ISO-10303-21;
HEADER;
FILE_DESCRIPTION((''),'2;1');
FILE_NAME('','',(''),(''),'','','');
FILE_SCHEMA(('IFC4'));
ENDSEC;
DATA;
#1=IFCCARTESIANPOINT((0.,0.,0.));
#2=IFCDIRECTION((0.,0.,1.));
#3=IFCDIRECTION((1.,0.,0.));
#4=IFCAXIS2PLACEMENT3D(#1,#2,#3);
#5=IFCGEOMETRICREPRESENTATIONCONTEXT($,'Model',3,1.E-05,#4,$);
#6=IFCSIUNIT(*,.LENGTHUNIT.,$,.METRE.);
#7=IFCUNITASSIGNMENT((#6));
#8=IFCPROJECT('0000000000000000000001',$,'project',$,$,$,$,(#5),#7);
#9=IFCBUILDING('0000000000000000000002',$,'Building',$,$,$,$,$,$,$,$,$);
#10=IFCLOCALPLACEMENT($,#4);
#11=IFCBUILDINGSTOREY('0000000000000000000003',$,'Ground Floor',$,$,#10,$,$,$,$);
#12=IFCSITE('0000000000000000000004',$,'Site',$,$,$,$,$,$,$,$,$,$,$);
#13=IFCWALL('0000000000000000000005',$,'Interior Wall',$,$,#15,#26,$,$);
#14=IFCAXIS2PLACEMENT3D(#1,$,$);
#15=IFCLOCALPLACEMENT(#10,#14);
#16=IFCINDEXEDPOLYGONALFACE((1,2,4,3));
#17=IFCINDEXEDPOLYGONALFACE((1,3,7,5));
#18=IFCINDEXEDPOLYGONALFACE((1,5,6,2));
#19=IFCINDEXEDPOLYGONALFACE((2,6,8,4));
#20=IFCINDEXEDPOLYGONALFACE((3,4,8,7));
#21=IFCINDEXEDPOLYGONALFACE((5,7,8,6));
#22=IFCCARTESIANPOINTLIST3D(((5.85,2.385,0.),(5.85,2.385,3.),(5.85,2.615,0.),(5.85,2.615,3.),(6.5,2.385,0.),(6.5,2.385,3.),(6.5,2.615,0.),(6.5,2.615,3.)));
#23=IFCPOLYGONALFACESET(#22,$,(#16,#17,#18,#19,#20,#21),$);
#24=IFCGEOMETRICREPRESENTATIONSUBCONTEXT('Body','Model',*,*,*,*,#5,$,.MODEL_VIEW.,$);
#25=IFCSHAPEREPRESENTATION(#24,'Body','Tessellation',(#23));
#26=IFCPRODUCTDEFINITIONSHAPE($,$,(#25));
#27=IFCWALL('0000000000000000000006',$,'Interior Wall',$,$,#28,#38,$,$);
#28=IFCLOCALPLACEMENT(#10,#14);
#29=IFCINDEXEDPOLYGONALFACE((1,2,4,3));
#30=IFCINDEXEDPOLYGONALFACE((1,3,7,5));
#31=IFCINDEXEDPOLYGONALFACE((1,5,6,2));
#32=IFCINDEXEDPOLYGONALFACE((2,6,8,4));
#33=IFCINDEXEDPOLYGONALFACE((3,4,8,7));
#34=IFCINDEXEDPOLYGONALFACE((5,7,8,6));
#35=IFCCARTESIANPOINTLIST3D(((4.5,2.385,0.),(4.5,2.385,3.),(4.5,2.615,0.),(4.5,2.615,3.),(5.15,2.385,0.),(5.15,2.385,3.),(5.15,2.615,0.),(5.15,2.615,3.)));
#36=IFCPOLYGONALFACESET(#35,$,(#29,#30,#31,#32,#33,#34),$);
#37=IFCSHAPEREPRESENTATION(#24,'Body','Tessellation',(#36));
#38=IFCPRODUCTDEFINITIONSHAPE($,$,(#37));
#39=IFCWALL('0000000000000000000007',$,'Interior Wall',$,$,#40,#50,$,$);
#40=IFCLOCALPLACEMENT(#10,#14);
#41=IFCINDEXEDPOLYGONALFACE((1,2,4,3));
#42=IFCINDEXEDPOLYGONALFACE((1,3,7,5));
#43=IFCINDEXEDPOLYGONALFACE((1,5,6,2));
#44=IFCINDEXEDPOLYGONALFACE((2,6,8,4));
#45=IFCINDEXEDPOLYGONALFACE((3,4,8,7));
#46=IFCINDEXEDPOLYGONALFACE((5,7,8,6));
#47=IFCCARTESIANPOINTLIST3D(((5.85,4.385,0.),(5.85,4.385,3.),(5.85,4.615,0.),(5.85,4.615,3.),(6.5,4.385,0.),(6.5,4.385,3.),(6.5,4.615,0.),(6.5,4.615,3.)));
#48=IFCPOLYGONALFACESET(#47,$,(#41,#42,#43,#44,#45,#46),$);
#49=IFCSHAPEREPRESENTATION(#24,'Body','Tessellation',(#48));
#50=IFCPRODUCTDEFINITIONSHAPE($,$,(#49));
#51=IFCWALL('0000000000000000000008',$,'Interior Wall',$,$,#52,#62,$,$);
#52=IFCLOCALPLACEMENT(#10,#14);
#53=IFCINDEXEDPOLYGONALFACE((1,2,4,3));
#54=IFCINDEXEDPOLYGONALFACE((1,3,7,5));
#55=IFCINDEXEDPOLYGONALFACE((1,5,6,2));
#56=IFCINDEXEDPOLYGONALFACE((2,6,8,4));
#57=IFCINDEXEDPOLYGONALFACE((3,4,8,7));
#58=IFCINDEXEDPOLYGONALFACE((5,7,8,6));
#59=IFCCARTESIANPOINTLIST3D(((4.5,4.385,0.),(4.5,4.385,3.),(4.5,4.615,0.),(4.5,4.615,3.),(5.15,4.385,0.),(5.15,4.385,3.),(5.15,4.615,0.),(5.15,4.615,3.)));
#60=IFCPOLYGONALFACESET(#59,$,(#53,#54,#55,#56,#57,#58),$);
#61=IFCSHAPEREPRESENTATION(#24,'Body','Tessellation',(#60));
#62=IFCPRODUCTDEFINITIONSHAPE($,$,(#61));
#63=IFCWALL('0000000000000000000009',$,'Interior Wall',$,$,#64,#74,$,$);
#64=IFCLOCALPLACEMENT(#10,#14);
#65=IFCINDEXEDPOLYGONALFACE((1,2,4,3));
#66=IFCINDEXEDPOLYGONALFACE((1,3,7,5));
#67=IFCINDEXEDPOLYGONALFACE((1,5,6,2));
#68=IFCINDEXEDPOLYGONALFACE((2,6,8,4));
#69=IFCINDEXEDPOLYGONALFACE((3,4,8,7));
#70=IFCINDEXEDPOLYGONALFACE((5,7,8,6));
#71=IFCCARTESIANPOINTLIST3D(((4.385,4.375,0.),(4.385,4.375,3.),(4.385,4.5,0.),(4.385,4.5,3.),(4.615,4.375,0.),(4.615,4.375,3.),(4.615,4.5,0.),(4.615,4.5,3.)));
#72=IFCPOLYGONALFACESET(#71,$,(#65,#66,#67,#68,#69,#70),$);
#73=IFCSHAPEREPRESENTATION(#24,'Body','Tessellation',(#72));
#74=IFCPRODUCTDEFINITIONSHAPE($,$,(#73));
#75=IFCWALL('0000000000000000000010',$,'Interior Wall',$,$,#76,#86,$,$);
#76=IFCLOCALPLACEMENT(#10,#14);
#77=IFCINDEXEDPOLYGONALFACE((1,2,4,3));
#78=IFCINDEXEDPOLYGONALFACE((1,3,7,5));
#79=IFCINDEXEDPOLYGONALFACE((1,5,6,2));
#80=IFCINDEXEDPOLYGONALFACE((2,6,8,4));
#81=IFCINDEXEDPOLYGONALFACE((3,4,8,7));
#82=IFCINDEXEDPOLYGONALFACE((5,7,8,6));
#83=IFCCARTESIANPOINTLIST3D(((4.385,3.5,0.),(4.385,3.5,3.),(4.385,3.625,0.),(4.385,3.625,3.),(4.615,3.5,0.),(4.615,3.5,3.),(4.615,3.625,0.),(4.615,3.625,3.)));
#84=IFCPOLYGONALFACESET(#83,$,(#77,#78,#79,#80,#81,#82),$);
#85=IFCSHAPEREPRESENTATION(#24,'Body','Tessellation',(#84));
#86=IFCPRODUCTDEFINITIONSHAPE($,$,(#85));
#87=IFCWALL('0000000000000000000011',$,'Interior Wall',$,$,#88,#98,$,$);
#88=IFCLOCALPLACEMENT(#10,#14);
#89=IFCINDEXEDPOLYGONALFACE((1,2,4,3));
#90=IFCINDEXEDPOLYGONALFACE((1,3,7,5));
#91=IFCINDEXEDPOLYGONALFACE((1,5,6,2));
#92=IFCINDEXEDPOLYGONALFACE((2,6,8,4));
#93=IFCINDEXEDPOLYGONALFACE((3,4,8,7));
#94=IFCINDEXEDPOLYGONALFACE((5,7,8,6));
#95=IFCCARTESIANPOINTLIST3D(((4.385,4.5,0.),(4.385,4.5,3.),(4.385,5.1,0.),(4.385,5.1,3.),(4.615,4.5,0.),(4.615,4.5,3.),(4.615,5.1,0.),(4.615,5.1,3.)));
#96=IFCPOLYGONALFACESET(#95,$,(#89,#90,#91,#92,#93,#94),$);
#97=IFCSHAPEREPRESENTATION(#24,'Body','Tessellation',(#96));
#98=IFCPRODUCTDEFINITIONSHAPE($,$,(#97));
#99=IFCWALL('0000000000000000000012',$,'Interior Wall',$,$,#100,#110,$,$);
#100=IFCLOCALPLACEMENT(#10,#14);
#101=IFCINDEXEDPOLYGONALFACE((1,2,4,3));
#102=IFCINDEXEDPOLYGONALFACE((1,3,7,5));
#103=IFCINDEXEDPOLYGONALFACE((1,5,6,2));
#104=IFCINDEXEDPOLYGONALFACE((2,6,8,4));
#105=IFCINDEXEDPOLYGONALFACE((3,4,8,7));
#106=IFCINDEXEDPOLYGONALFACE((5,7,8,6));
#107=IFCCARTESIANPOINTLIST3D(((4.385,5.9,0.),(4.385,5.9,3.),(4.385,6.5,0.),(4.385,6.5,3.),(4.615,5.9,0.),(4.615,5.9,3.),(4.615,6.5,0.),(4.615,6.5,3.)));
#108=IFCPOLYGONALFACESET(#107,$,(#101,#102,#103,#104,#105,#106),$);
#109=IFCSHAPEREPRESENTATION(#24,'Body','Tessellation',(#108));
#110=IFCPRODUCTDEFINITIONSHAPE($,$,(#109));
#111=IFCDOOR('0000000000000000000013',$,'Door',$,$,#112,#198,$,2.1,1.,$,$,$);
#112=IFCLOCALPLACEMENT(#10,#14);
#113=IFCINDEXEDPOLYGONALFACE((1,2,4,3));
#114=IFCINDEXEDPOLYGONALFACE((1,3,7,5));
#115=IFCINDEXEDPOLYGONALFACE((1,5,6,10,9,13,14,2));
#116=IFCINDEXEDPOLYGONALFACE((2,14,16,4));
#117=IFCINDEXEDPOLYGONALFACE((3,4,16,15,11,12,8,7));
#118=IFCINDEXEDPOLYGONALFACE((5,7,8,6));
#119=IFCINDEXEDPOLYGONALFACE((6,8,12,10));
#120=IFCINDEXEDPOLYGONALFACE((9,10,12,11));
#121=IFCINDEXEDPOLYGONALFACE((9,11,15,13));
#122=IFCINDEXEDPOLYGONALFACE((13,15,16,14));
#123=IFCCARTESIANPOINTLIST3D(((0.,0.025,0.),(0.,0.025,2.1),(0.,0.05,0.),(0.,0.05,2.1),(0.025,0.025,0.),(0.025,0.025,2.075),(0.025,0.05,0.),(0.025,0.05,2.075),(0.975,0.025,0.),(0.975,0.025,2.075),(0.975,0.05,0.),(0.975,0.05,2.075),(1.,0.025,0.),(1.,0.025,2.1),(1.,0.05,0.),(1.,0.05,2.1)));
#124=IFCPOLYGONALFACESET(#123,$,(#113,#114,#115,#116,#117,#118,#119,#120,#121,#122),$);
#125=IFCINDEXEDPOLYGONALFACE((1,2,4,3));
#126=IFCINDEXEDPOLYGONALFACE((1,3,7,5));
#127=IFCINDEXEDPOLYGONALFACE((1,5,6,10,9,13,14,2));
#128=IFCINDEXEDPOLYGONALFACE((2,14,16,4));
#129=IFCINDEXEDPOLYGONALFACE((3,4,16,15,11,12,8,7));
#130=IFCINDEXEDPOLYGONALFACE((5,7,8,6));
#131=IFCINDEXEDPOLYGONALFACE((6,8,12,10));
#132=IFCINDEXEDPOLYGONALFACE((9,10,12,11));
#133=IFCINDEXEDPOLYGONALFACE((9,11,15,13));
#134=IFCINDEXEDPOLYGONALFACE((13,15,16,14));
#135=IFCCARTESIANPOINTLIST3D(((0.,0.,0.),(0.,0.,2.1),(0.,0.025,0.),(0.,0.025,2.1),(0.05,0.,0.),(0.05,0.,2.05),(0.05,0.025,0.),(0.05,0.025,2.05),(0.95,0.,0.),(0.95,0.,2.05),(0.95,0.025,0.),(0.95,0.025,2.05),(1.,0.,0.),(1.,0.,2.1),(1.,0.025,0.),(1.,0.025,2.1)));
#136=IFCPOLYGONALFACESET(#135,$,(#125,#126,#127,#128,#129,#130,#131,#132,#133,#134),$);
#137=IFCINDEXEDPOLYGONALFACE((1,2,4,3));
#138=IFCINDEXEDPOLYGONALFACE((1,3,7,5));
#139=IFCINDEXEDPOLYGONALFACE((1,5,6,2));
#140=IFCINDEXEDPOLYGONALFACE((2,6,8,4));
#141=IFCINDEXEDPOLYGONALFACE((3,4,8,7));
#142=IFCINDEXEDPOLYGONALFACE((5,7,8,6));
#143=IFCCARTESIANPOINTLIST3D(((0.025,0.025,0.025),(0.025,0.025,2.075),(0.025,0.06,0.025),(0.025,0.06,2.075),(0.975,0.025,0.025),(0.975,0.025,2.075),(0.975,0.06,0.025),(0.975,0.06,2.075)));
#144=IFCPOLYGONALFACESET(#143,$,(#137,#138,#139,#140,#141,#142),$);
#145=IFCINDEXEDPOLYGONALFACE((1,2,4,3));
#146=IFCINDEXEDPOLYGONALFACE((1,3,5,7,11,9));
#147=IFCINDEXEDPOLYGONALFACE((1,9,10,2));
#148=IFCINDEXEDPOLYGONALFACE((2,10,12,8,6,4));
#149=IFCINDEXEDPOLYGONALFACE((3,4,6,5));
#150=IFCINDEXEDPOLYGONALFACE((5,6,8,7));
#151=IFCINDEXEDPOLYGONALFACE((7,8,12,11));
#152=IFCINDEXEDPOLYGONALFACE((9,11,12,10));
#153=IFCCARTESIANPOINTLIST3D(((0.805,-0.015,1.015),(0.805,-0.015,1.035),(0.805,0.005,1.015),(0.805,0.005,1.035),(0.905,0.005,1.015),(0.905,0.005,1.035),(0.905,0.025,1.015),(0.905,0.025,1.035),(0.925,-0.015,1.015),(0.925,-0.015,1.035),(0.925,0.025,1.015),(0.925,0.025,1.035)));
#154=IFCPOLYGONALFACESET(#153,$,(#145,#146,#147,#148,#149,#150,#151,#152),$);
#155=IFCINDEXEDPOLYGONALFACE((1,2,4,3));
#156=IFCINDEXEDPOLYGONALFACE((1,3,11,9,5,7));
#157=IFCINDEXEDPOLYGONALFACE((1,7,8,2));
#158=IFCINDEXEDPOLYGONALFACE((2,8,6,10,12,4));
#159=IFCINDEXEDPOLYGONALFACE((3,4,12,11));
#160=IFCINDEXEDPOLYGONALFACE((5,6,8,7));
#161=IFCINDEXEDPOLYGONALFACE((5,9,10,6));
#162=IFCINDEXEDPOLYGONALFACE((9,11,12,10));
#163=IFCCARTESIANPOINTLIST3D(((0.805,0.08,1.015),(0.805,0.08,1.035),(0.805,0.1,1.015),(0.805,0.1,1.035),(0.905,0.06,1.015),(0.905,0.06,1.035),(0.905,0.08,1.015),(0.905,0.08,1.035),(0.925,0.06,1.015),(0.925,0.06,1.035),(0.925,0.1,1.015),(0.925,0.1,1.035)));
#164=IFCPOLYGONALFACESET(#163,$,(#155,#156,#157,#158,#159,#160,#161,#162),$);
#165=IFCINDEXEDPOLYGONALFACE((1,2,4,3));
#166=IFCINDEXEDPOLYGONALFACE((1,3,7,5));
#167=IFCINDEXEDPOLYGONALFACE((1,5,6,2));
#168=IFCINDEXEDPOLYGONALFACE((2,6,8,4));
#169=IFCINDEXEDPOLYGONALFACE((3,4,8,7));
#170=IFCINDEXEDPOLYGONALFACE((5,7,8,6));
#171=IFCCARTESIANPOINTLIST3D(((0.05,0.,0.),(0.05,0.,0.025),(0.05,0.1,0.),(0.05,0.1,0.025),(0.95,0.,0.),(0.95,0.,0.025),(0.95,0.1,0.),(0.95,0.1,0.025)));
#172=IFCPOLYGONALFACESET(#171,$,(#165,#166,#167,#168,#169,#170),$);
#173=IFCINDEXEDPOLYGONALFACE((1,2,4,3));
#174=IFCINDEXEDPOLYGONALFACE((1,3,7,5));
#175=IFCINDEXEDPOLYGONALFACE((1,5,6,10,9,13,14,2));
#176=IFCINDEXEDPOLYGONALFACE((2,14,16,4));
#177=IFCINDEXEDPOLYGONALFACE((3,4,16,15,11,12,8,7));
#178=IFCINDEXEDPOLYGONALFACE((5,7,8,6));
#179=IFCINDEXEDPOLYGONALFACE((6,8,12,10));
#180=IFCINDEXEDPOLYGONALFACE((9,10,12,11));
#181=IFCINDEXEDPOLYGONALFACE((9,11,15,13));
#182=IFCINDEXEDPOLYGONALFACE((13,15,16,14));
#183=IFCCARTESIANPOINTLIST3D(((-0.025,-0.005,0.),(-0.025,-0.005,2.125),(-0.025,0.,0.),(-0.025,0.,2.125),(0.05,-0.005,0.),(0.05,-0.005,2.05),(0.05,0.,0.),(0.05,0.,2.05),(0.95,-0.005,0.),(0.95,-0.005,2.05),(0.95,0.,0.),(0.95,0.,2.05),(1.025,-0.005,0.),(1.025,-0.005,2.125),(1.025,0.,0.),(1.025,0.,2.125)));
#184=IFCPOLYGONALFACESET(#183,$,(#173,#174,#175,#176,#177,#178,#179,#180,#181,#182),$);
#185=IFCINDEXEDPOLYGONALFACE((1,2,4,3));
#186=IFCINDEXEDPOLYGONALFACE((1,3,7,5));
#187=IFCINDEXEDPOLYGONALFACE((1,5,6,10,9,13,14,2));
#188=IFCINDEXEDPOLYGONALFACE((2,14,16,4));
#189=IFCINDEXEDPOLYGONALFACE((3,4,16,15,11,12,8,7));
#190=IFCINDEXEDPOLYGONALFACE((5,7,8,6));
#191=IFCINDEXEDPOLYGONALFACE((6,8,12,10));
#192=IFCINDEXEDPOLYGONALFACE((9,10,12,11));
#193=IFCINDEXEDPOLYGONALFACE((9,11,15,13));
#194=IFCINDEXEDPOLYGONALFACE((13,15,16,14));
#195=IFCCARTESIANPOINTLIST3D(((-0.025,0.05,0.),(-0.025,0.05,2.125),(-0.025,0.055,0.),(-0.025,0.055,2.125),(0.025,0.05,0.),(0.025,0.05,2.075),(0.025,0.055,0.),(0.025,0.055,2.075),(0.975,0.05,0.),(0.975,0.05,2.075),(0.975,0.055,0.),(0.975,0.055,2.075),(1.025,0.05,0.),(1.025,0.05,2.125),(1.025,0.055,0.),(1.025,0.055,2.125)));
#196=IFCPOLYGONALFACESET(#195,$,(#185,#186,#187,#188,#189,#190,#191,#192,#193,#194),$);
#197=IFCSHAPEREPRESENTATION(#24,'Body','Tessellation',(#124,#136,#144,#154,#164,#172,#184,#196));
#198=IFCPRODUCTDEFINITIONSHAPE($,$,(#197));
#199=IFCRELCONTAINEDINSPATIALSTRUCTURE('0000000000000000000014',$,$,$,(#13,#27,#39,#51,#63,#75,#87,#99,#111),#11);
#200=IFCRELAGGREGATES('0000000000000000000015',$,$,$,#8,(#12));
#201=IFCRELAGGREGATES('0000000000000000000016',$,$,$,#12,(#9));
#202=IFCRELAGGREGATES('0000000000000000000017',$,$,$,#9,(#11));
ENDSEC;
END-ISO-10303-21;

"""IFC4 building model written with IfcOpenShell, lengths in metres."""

from ifc_helpers import new_model, si_unit, frame, origin_with_axes, place, context, subcontext, project, spatial, line, indexed_curve, outline, extrude, element, save


model = new_model("IFC4")

# Units and contexts
model_context = context("Model", 3, precision=1e-05, world=origin_with_axes())
body_context = subcontext(model_context, "Body", "Model", "MODEL_VIEW")
ifc_project = project(units=[si_unit("LENGTHUNIT", "METRE")], contexts=[model_context])

# Site, building, storey
site = spatial("IfcSite", under=ifc_project, Name="Site")
building = spatial("IfcBuilding", under=site, Name="Building")
storey_placement = place(None, origin_with_axes())
storey = spatial("IfcBuildingStorey", under=building, at=storey_placement, Name="Ground Floor")

# Walls
for number, where, z_axis, x_axis, name in (
    (1, (6.5, 2.5, 0.0), (0.0, 0.0, 1.0), (-1.0, 0.0, 0.0), "Interior Wall"),
    (2, (5.15, 2.5, 0.0), (0.0, 0.0, 1.0), (-1.0, 0.0, 0.0), "Interior Wall"),
    (3, (6.5, 4.5, 0.0), (0.0, 0.0, 1.0), (-1.0, 0.0, 0.0), "Interior Wall"),
    (4, (5.15, 4.5, 0.0), (0.0, 0.0, 1.0), (-1.0, 0.0, 0.0), "Interior Wall"),
):
    element("IfcWall", number, at=place(storey_placement, frame(where, z_axis=z_axis, x_axis=x_axis)), inside=storey, Name=name, context=body_context, shape_type="SweptSolid", body=[
        extrude(outline(indexed_curve([(0.0, 0.0), (0.0, 0.23), (0.65, 0.23), (0.65, 0.0), (0.0, 0.0)], self_intersect=False)), frame((0.0, -0.115, 0.0), z_axis=(0.0, 0.0, 1.0), x_axis=(1.0, 0.0, 0.0)), (0.0, 0.0, 1.0), 3.0),
    ])
for number, where, z_axis, x_axis, name in (
    (5, (4.5, 4.5, 0.0), (0.0, 0.0, 1.0), (0.0, -1.0, 0.0), "Interior Wall"),
    (6, (4.5, 3.625, 0.0), (0.0, 0.0, 1.0), (0.0, -1.0, 0.0), "Interior Wall"),
):
    element("IfcWall", number, at=place(storey_placement, frame(where, z_axis=z_axis, x_axis=x_axis)), inside=storey, Name=name, context=body_context, shape_type="SweptSolid", body=[
        extrude(outline(indexed_curve([(0.0, 0.0), (0.0, 0.23), (0.125, 0.23), (0.125, 0.0), (0.0, 0.0)], self_intersect=False)), frame((0.0, -0.115, 0.0), z_axis=(0.0, 0.0, 1.0), x_axis=(1.0, 0.0, 0.0)), (0.0, 0.0, 1.0), 3.0),
    ])
for number, where, z_axis, x_axis, name in (
    (7, (4.5, 4.5, 0.0), (0.0, 0.0, 1.0), (0.0, 1.0, 0.0), "Interior Wall"),
    (8, (4.5, 5.9, 0.0), (0.0, 0.0, 1.0), (0.0, 1.0, 0.0), "Interior Wall"),
):
    element("IfcWall", number, at=place(storey_placement, frame(where, z_axis=z_axis, x_axis=x_axis)), inside=storey, Name=name, context=body_context, shape_type="SweptSolid", body=[
        extrude(outline(indexed_curve([(0.0, 0.0), (0.0, 0.23), (0.6, 0.23), (0.6, 0.0), (0.0, 0.0)], self_intersect=False)), frame((0.0, -0.115, 0.0), z_axis=(0.0, 0.0, 1.0), x_axis=(1.0, 0.0, 0.0)), (0.0, 0.0, 1.0), 3.0),
    ])

# Door
door_1_placement = place(storey_placement, origin_with_axes())
element("IfcDoor", 9, at=door_1_placement, inside=storey, Name="Door", OverallHeight=2.1, OverallWidth=1.0, context=body_context, shape_type="SweptSolid", body=[
    extrude(outline(indexed_curve([(0.0, 0.0), (0.0, 2.1), (1.0, 2.1), (1.0, 0.0), (0.975, 0.0), (0.975, 2.075), (0.025, 2.075), (0.025, 0.0)], segments=[line(1, 2, 3, 4, 5, 6, 7, 8, 1)])), frame((0.0, 0.025, 0.0), z_axis=(0.0, -1.0, 0.0), x_axis=(1.0, 0.0, 0.0)), (0.0, 0.0, -1.0), 0.025),
    extrude(outline(indexed_curve([(0.0, 0.0), (0.0, 2.1), (1.0, 2.1), (1.0, 0.0), (0.95, 0.0), (0.95, 2.05), (0.05, 2.05), (0.05, 0.0)], segments=[line(1, 2, 3, 4, 5, 6, 7, 8, 1)])), frame((0.0, 0.0, 0.0), z_axis=(0.0, -1.0, 0.0), x_axis=(1.0, 0.0, 0.0)), (0.0, 0.0, -1.0), 0.025),
    extrude(outline(indexed_curve([(0.0, 0.0), (0.95, 0.0), (0.95, 0.035), (0.0, 0.035)], segments=[line(1, 2, 3, 4, 1)])), frame((0.025, 0.025, 0.025), z_axis=(0.0, 0.0, 1.0), x_axis=(1.0, 0.0, 0.0)), (0.0, 0.0, 1.0), 2.05),
    extrude(outline(indexed_curve([(0.0, 0.0), (0.0, -0.04), (-0.12, -0.04), (-0.12, -0.02), (-0.02, -0.02), (-0.02, 0.0)], segments=[line(1, 2, 3, 4, 5, 6, 1)])), frame((0.925, 0.025, 1.015), z_axis=(0.0, 0.0, 1.0), x_axis=(1.0, 0.0, 0.0)), (0.0, 0.0, 1.0), 0.02),
    extrude(outline(indexed_curve([(0.0, 0.0), (0.0, 0.04), (-0.12, 0.04), (-0.12, 0.02), (-0.02, 0.02), (-0.02, 0.0)], segments=[line(1, 2, 3, 4, 5, 6, 1)])), frame((0.925, 0.06, 1.015), z_axis=(0.0, 0.0, 1.0), x_axis=(1.0, 0.0, 0.0)), (0.0, 0.0, 1.0), 0.02),
    extrude(outline(indexed_curve([(0.0, 0.0), (0.9, 0.0), (0.9, 0.1), (0.0, 0.1)], segments=[line(1, 2, 3, 4, 1)])), frame((0.05, 0.0, 0.0), z_axis=(0.0, 0.0, 1.0), x_axis=(1.0, 0.0, 0.0)), (0.0, 0.0, 1.0), 0.025),
    extrude(outline(indexed_curve([(0.0, 0.0), (0.0, 2.125), (1.05, 2.125), (1.05, 0.0), (0.975, 0.0), (0.975, 2.05), (0.075, 2.05), (0.075, 0.0)], segments=[line(1, 2, 3, 4, 5, 6, 7, 8, 1)])), frame((-0.025, -0.005, 0.0), z_axis=(0.0, -1.0, 0.0), x_axis=(1.0, 0.0, 0.0)), (0.0, 0.0, -1.0), 0.005),
    extrude(outline(indexed_curve([(0.0, 0.0), (0.0, 2.125), (1.05, 2.125), (1.05, 0.0), (1.0, 0.0), (1.0, 2.075), (0.05, 2.075), (0.05, 0.0)], segments=[line(1, 2, 3, 4, 5, 6, 7, 8, 1)])), frame((-0.025, 0.05, 0.0), z_axis=(0.0, -1.0, 0.0), x_axis=(1.0, 0.0, 0.0)), (0.0, 0.0, -1.0), 0.005),
])

save(model, "model.ifc")
